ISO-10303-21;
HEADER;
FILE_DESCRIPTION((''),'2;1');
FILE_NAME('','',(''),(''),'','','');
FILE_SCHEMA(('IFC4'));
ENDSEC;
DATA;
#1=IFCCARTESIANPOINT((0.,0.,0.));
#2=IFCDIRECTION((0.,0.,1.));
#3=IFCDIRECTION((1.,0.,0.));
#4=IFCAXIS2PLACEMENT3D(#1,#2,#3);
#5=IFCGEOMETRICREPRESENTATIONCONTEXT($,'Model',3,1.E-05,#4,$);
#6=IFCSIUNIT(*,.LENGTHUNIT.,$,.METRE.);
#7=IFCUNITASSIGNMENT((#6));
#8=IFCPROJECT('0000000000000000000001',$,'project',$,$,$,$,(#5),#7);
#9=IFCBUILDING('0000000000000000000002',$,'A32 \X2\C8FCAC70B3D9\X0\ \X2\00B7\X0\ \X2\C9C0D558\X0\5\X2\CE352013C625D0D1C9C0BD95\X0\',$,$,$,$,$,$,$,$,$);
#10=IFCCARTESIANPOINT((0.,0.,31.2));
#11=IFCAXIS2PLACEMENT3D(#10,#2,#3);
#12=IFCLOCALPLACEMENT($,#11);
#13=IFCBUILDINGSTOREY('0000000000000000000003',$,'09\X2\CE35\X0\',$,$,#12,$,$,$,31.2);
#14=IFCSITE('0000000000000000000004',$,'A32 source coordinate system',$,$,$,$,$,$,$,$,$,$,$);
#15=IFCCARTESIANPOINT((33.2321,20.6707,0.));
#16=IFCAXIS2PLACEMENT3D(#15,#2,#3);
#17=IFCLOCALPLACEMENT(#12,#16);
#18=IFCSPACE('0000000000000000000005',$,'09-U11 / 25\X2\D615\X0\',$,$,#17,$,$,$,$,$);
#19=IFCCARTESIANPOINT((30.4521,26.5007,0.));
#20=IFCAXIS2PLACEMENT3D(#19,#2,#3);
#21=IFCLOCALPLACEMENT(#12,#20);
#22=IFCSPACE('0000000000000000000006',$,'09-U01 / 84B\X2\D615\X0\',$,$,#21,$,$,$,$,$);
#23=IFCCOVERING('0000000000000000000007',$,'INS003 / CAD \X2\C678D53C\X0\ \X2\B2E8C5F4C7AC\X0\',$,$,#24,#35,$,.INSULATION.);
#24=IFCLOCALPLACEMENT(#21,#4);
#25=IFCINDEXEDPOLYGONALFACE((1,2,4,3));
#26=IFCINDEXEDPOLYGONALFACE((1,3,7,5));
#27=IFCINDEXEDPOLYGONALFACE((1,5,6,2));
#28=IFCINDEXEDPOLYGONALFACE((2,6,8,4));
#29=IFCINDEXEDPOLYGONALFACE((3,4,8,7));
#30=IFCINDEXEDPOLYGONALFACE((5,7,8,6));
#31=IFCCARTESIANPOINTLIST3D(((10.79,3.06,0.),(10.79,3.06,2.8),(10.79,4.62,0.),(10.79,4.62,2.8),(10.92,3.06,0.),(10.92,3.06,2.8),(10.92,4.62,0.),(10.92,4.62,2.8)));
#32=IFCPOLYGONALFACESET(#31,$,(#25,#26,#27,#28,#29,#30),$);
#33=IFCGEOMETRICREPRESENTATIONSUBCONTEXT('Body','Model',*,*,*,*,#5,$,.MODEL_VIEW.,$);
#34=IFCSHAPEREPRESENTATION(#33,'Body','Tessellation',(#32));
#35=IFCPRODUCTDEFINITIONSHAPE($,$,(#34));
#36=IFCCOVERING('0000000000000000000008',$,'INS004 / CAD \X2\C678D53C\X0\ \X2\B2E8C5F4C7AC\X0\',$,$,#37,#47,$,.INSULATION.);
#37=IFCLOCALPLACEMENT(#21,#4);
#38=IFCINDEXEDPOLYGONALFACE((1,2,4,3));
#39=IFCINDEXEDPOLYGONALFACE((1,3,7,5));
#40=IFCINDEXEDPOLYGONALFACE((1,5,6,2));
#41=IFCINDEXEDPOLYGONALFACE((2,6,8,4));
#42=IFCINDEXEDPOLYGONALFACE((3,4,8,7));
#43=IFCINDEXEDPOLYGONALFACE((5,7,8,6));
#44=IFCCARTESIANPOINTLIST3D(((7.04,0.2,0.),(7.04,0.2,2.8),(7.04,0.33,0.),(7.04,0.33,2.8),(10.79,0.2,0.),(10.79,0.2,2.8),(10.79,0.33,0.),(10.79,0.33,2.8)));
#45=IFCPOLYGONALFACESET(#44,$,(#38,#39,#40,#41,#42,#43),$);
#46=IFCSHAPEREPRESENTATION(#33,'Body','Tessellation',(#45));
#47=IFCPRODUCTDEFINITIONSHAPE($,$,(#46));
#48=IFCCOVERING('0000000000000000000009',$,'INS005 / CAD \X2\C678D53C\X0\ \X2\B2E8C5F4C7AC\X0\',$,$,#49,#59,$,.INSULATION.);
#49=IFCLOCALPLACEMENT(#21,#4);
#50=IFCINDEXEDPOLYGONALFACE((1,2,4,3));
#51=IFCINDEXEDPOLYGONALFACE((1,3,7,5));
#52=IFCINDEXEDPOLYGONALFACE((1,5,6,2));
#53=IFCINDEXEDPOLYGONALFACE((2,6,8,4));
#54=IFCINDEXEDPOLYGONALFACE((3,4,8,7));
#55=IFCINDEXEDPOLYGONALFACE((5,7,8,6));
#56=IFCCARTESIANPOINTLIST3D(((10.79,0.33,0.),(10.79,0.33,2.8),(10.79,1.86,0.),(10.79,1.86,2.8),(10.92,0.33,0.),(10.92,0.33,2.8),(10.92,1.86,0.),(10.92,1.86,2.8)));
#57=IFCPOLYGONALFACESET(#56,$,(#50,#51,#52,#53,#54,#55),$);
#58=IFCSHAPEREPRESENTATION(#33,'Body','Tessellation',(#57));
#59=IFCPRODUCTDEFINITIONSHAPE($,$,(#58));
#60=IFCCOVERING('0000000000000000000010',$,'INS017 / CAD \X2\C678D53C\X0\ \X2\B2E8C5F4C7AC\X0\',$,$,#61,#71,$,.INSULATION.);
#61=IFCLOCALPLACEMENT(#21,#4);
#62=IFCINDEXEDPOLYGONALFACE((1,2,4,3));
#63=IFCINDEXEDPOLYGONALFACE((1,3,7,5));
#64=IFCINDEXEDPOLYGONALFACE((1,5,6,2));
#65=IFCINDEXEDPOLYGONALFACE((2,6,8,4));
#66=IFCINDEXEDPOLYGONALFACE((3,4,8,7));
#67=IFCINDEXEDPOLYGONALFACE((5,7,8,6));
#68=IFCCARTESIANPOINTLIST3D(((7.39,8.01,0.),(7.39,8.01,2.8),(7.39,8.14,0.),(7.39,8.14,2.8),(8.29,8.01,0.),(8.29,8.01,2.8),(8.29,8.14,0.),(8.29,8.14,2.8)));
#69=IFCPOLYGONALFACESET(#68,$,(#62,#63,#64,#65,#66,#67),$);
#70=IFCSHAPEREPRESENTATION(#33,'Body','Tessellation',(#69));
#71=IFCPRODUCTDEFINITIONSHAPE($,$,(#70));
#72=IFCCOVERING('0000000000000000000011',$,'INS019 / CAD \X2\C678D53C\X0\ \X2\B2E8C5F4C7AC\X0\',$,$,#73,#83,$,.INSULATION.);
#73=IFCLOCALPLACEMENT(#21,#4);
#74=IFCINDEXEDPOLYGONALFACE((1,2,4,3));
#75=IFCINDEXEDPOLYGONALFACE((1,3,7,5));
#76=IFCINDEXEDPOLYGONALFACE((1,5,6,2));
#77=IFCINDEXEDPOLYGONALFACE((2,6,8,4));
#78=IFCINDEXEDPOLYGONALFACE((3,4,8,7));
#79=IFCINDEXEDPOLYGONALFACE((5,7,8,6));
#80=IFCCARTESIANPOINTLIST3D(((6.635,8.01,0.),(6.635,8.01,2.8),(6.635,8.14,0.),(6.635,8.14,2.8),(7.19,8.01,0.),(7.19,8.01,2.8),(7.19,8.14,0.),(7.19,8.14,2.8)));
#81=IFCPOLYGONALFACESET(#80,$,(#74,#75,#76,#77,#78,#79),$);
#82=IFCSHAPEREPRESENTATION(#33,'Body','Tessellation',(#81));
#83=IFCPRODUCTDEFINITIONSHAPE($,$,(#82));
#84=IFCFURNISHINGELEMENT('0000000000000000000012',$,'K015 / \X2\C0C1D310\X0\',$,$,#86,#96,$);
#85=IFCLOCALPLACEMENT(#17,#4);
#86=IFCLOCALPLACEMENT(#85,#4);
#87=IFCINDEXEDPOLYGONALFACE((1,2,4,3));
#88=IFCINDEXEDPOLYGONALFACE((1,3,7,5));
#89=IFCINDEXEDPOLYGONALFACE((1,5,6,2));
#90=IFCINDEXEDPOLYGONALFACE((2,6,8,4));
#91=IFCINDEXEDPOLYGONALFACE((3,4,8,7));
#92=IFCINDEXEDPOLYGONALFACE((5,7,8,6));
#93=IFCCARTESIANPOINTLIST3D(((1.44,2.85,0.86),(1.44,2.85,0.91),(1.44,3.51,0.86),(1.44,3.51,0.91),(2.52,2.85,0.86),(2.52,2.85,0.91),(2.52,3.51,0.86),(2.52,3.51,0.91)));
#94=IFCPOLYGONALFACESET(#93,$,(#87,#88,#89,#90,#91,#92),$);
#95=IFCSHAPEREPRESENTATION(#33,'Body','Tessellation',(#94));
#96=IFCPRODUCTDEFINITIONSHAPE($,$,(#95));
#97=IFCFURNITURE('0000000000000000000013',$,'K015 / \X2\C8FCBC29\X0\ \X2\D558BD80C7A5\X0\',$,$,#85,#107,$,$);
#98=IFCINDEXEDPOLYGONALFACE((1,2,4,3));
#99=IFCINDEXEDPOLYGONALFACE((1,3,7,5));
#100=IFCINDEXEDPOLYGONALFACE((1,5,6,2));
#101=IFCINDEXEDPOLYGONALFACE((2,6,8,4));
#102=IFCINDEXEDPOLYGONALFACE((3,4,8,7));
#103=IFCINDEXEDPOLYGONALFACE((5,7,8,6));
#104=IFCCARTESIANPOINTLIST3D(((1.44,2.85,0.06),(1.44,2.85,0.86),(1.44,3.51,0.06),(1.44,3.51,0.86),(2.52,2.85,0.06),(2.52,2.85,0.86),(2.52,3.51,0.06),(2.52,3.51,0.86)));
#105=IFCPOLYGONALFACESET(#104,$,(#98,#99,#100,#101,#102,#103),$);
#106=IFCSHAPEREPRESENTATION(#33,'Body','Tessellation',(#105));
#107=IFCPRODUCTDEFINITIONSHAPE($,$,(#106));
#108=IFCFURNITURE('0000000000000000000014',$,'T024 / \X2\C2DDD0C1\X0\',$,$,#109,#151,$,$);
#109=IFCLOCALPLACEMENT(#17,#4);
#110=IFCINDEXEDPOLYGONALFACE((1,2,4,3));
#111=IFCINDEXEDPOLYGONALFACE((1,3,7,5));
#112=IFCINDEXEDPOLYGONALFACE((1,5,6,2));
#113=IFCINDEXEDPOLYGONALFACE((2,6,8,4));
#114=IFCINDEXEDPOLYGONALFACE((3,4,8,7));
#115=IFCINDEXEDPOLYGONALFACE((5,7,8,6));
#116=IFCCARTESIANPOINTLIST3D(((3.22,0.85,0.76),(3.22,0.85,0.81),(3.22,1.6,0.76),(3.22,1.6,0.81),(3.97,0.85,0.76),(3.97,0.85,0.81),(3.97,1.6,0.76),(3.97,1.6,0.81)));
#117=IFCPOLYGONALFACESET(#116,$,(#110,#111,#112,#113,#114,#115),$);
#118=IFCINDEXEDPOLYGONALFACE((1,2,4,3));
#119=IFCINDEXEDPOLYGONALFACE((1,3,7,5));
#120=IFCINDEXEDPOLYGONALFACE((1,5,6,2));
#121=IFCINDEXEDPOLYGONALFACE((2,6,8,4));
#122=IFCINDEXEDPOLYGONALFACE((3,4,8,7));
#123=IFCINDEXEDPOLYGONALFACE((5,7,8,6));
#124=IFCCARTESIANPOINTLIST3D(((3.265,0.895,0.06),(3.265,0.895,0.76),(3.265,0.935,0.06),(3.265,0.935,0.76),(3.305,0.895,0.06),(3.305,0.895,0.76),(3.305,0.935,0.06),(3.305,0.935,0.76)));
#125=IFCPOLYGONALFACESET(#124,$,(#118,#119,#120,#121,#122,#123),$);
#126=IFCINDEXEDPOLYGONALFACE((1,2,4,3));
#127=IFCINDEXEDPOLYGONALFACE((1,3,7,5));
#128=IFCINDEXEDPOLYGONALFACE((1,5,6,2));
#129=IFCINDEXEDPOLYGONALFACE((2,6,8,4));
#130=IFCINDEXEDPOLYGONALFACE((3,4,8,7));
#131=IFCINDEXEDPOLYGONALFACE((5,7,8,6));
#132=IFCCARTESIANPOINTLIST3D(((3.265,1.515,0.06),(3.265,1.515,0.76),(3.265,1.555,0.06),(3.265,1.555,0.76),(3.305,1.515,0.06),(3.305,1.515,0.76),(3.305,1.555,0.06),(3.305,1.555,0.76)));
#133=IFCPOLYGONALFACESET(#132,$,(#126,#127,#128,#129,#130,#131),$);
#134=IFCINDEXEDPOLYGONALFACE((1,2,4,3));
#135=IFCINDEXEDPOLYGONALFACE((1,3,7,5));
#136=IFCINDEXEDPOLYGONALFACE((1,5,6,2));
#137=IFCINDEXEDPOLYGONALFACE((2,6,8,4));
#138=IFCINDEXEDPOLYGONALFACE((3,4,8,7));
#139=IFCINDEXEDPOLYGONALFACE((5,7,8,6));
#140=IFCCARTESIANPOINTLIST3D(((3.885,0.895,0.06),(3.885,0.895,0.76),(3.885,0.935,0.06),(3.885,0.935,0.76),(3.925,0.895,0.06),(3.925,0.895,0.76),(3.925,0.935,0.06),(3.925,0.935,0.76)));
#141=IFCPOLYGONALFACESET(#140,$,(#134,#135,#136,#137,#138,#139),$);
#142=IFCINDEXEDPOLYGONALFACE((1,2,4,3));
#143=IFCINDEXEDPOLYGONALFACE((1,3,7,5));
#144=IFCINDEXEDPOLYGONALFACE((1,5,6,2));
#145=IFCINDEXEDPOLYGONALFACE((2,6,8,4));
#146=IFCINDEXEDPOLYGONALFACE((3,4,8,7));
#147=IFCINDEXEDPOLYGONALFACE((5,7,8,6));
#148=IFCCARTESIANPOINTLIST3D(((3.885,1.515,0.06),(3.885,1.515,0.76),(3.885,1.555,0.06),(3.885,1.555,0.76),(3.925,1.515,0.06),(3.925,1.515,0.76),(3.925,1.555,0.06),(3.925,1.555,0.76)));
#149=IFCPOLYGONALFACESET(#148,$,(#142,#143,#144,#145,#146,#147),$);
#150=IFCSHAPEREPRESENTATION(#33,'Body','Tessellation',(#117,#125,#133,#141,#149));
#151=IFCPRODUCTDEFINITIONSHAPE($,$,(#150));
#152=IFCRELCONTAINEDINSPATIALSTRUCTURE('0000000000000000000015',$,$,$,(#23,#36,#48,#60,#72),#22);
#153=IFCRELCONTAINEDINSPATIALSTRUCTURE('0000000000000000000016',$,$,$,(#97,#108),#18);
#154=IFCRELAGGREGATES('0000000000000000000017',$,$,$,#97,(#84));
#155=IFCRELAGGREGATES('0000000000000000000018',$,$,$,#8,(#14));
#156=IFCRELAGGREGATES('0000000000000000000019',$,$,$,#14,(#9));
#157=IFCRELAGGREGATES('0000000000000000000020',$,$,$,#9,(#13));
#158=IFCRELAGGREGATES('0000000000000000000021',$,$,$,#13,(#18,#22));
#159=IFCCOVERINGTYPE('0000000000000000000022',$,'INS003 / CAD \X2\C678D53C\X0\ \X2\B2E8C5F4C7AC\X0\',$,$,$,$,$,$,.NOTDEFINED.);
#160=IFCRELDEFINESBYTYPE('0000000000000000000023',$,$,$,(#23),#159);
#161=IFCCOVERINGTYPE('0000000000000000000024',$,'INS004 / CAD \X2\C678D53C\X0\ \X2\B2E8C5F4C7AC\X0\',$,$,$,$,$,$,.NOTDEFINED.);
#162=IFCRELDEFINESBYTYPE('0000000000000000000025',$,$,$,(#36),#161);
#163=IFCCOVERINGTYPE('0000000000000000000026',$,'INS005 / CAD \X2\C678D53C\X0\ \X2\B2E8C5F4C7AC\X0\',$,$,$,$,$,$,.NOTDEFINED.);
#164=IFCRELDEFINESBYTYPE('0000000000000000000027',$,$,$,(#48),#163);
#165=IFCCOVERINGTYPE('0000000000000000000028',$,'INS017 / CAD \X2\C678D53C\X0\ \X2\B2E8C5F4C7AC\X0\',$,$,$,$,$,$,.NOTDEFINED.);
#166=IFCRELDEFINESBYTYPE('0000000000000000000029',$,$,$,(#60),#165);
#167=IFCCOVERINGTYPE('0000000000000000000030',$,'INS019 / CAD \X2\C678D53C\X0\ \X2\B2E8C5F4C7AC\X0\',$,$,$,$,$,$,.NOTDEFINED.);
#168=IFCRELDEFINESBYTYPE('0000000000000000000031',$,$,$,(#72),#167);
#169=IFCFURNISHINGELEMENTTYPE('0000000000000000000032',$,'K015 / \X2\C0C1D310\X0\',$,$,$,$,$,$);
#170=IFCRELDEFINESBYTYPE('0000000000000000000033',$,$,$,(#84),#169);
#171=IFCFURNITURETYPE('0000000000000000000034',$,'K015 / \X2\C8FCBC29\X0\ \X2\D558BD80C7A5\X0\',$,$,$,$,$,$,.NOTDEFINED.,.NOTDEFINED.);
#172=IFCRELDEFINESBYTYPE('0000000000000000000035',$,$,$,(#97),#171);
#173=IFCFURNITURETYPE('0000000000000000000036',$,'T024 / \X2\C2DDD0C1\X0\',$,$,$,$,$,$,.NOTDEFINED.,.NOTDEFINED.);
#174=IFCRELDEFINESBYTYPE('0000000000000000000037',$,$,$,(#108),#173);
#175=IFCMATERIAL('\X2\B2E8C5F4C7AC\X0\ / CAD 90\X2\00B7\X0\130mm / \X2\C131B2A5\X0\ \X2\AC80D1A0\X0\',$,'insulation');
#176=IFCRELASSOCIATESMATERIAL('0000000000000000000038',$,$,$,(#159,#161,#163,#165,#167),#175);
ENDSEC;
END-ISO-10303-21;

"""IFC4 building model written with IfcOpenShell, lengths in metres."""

from ifc_helpers import new_model, si_unit, frame, origin, origin_with_axes, place, context, subcontext, project, spatial, polyline, outline, extrude, source, transform, mapped, material, type_object, type_shapes, element, aggregate, save


model = new_model("IFC4")

# Units and contexts
model_context = context("Model", 3, precision=1e-05, world=origin_with_axes())
body_context = subcontext(model_context, "Body", "Model", "MODEL_VIEW")
ifc_project = project(units=[si_unit("LENGTHUNIT", "METRE")], contexts=[model_context])

# Site, building, storey, space
site = spatial("IfcSite", under=ifc_project, Name="A32 source coordinate system")
building = spatial("IfcBuilding", under=site, Name="A32 주거동 · 지하5층–옥탑지붕")
storey_placement = place(None, frame((0.0, 0.0, 31.2), z_axis=(0.0, 0.0, 1.0), x_axis=(1.0, 0.0, 0.0)))
storey = spatial("IfcBuildingStorey", under=building, at=storey_placement, Name="09층", Elevation=31.2)
space_1_placement = place(storey_placement, frame((33.2321, 20.6707, 0.0), z_axis=(0.0, 0.0, 1.0), x_axis=(1.0, 0.0, 0.0)))
space_1 = spatial("IfcSpace", under=storey, at=space_1_placement, Name="09-U11 / 25형")

# Shared definitions
space_2_placement = place(storey_placement, frame((30.4521, 26.5007, 0.0), z_axis=(0.0, 0.0, 1.0), x_axis=(1.0, 0.0, 0.0)))
space_2 = spatial("IfcSpace", under=storey, at=space_2_placement, Name="09-U01 / 84B형")

# Coverings
ifc_material = material(Name="단열재 / CAD 90·130mm / 성능 검토", Category="insulation")
covering_type_1 = type_object("IfcCoveringType", Name="INS003 / CAD 외피 단열재", PredefinedType="NOTDEFINED", material=ifc_material)
shared_shape_1 = source(origin(), body_context, "Body", "SweptSolid", [
    extrude(outline(polyline([(10.79, 3.06), (10.79, 4.62), (10.92, 4.62), (10.92, 3.06), (10.79, 3.06)])), origin(), (0.0, 0.0, 1.0), 2.8),
])
type_shapes(covering_type_1, [shared_shape_1])
covering_1_placement = place(space_2_placement, origin_with_axes())
element("IfcCovering", 1, at=covering_1_placement, inside=space_2, type_object=covering_type_1, Name="INS003 / CAD 외피 단열재", PredefinedType="INSULATION", context=body_context, shape_type="MappedRepresentation", body=[
    mapped(shared_shape_1, transform((0.0, 0.0, 0.0), scale=1.0)),
])
covering_type_2 = type_object("IfcCoveringType", Name="INS004 / CAD 외피 단열재", PredefinedType="NOTDEFINED", material=ifc_material)
shared_shape_2 = source(origin(), body_context, "Body", "SweptSolid", [
    extrude(outline(polyline([(7.04, 0.33), (10.79, 0.33), (10.79, 0.2), (7.04, 0.2), (7.04, 0.33)])), origin(), (0.0, 0.0, 1.0), 2.8),
])
type_shapes(covering_type_2, [shared_shape_2])
covering_2_placement = place(space_2_placement, origin_with_axes())
element("IfcCovering", 2, at=covering_2_placement, inside=space_2, type_object=covering_type_2, Name="INS004 / CAD 외피 단열재", PredefinedType="INSULATION", context=body_context, shape_type="MappedRepresentation", body=[
    mapped(shared_shape_2, transform((0.0, 0.0, 0.0), scale=1.0)),
])
covering_type_3 = type_object("IfcCoveringType", Name="INS005 / CAD 외피 단열재", PredefinedType="NOTDEFINED", material=ifc_material)
shared_shape_3 = source(origin(), body_context, "Body", "SweptSolid", [
    extrude(outline(polyline([(10.79, 0.33), (10.79, 1.86), (10.92, 1.86), (10.92, 0.33), (10.79, 0.33)])), origin(), (0.0, 0.0, 1.0), 2.8),
])
type_shapes(covering_type_3, [shared_shape_3])
covering_3_placement = place(space_2_placement, origin_with_axes())
element("IfcCovering", 3, at=covering_3_placement, inside=space_2, type_object=covering_type_3, Name="INS005 / CAD 외피 단열재", PredefinedType="INSULATION", context=body_context, shape_type="MappedRepresentation", body=[
    mapped(shared_shape_3, transform((0.0, 0.0, 0.0), scale=1.0)),
])
covering_type_4 = type_object("IfcCoveringType", Name="INS017 / CAD 외피 단열재", PredefinedType="NOTDEFINED", material=ifc_material)
shared_shape_4 = source(origin(), body_context, "Body", "SweptSolid", [
    extrude(outline(polyline([(8.29, 8.01), (7.39, 8.01), (7.39, 8.14), (8.29, 8.14), (8.29, 8.01)])), origin(), (0.0, 0.0, 1.0), 2.8),
])
type_shapes(covering_type_4, [shared_shape_4])
covering_4_placement = place(space_2_placement, origin_with_axes())
element("IfcCovering", 4, at=covering_4_placement, inside=space_2, type_object=covering_type_4, Name="INS017 / CAD 외피 단열재", PredefinedType="INSULATION", context=body_context, shape_type="MappedRepresentation", body=[
    mapped(shared_shape_4, transform((0.0, 0.0, 0.0), scale=1.0)),
])
covering_type_5 = type_object("IfcCoveringType", Name="INS019 / CAD 외피 단열재", PredefinedType="NOTDEFINED", material=ifc_material)
shared_shape_5 = source(origin(), body_context, "Body", "SweptSolid", [
    extrude(outline(polyline([(6.635, 8.01), (6.635, 8.14), (7.19, 8.14), (7.19, 8.01), (6.635, 8.01)])), origin(), (0.0, 0.0, 1.0), 2.8),
])
type_shapes(covering_type_5, [shared_shape_5])
covering_5_placement = place(space_2_placement, origin_with_axes())
element("IfcCovering", 5, at=covering_5_placement, inside=space_2, type_object=covering_type_5, Name="INS019 / CAD 외피 단열재", PredefinedType="INSULATION", context=body_context, shape_type="MappedRepresentation", body=[
    mapped(shared_shape_5, transform((0.0, 0.0, 0.0), scale=1.0)),
])

# Furnishing element
furnishing_element_type_1 = type_object("IfcFurnishingElementType", Name="K015 / 상판")
shared_shape_6 = source(origin(), body_context, "Body", "SweptSolid", [
    extrude(outline(polyline([(2.52, 2.85), (1.44, 2.85), (1.44, 3.51), (2.52, 3.51), (2.52, 2.85)])), frame((0.0, 0.0, 0.86)), (0.0, 0.0, 1.0), 0.05),
])
type_shapes(furnishing_element_type_1, [shared_shape_6])
furniture_1_placement = place(space_1_placement, origin_with_axes())
furnishing_1_placement = place(furniture_1_placement, origin_with_axes())
furnishing_1 = element("IfcFurnishingElement", 6, at=furnishing_1_placement, type_object=furnishing_element_type_1, Name="K015 / 상판", context=body_context, shape_type="MappedRepresentation", body=[
    mapped(shared_shape_6, transform((0.0, 0.0, 0.0), scale=1.0)),
])

# Furniture
furniture_type_1 = type_object("IfcFurnitureType", Name="K015 / 주방 하부장", AssemblyPlace="NOTDEFINED", PredefinedType="NOTDEFINED")
shared_shape_7 = source(origin(), body_context, "Body", "SweptSolid", [
    extrude(outline(polyline([(2.52, 3.51), (2.52, 2.85), (1.44, 2.85), (1.44, 3.51), (2.52, 3.51)])), frame((0.0, 0.0, 0.06)), (0.0, 0.0, 1.0), 0.8),
])
type_shapes(furniture_type_1, [shared_shape_7])
furniture_1 = element("IfcFurniture", 7, at=furniture_1_placement, inside=space_1, type_object=furniture_type_1, Name="K015 / 주방 하부장", context=body_context, shape_type="MappedRepresentation", body=[
    mapped(shared_shape_7, transform((0.0, 0.0, 0.0), scale=1.0)),
])
aggregate(furniture_1, [furnishing_1])
furniture_type_2 = type_object("IfcFurnitureType", Name="T024 / 식탁", AssemblyPlace="NOTDEFINED", PredefinedType="NOTDEFINED")
shared_shape_8 = source(origin(), body_context, "Body", "SweptSolid", [
    extrude(outline(polyline([(3.22, 0.85), (3.22, 1.6), (3.97, 1.6), (3.97, 0.85), (3.22, 0.85)])), frame((0.0, 0.0, 0.76)), (0.0, 0.0, 1.0), 0.05),
    extrude(outline(polyline([(3.265, 0.895), (3.265, 0.935), (3.305, 0.935), (3.305, 0.895), (3.265, 0.895)])), frame((0.0, 0.0, 0.06)), (0.0, 0.0, 1.0), 0.7),
    extrude(outline(polyline([(3.265, 1.515), (3.265, 1.555), (3.305, 1.555), (3.305, 1.515), (3.265, 1.515)])), frame((0.0, 0.0, 0.06)), (0.0, 0.0, 1.0), 0.7),
    extrude(outline(polyline([(3.885, 0.895), (3.885, 0.935), (3.925, 0.935), (3.925, 0.895), (3.885, 0.895)])), frame((0.0, 0.0, 0.06)), (0.0, 0.0, 1.0), 0.7),
    extrude(outline(polyline([(3.885, 1.515), (3.885, 1.555), (3.925, 1.555), (3.925, 1.515), (3.885, 1.515)])), frame((0.0, 0.0, 0.06)), (0.0, 0.0, 1.0), 0.7),
])
type_shapes(furniture_type_2, [shared_shape_8])
furniture_2_placement = place(space_1_placement, origin_with_axes())
element("IfcFurniture", 8, at=furniture_2_placement, inside=space_1, type_object=furniture_type_2, Name="T024 / 식탁", context=body_context, shape_type="MappedRepresentation", body=[
    mapped(shared_shape_8, transform((0.0, 0.0, 0.0), scale=1.0)),
])

save(model, "model.ifc")
